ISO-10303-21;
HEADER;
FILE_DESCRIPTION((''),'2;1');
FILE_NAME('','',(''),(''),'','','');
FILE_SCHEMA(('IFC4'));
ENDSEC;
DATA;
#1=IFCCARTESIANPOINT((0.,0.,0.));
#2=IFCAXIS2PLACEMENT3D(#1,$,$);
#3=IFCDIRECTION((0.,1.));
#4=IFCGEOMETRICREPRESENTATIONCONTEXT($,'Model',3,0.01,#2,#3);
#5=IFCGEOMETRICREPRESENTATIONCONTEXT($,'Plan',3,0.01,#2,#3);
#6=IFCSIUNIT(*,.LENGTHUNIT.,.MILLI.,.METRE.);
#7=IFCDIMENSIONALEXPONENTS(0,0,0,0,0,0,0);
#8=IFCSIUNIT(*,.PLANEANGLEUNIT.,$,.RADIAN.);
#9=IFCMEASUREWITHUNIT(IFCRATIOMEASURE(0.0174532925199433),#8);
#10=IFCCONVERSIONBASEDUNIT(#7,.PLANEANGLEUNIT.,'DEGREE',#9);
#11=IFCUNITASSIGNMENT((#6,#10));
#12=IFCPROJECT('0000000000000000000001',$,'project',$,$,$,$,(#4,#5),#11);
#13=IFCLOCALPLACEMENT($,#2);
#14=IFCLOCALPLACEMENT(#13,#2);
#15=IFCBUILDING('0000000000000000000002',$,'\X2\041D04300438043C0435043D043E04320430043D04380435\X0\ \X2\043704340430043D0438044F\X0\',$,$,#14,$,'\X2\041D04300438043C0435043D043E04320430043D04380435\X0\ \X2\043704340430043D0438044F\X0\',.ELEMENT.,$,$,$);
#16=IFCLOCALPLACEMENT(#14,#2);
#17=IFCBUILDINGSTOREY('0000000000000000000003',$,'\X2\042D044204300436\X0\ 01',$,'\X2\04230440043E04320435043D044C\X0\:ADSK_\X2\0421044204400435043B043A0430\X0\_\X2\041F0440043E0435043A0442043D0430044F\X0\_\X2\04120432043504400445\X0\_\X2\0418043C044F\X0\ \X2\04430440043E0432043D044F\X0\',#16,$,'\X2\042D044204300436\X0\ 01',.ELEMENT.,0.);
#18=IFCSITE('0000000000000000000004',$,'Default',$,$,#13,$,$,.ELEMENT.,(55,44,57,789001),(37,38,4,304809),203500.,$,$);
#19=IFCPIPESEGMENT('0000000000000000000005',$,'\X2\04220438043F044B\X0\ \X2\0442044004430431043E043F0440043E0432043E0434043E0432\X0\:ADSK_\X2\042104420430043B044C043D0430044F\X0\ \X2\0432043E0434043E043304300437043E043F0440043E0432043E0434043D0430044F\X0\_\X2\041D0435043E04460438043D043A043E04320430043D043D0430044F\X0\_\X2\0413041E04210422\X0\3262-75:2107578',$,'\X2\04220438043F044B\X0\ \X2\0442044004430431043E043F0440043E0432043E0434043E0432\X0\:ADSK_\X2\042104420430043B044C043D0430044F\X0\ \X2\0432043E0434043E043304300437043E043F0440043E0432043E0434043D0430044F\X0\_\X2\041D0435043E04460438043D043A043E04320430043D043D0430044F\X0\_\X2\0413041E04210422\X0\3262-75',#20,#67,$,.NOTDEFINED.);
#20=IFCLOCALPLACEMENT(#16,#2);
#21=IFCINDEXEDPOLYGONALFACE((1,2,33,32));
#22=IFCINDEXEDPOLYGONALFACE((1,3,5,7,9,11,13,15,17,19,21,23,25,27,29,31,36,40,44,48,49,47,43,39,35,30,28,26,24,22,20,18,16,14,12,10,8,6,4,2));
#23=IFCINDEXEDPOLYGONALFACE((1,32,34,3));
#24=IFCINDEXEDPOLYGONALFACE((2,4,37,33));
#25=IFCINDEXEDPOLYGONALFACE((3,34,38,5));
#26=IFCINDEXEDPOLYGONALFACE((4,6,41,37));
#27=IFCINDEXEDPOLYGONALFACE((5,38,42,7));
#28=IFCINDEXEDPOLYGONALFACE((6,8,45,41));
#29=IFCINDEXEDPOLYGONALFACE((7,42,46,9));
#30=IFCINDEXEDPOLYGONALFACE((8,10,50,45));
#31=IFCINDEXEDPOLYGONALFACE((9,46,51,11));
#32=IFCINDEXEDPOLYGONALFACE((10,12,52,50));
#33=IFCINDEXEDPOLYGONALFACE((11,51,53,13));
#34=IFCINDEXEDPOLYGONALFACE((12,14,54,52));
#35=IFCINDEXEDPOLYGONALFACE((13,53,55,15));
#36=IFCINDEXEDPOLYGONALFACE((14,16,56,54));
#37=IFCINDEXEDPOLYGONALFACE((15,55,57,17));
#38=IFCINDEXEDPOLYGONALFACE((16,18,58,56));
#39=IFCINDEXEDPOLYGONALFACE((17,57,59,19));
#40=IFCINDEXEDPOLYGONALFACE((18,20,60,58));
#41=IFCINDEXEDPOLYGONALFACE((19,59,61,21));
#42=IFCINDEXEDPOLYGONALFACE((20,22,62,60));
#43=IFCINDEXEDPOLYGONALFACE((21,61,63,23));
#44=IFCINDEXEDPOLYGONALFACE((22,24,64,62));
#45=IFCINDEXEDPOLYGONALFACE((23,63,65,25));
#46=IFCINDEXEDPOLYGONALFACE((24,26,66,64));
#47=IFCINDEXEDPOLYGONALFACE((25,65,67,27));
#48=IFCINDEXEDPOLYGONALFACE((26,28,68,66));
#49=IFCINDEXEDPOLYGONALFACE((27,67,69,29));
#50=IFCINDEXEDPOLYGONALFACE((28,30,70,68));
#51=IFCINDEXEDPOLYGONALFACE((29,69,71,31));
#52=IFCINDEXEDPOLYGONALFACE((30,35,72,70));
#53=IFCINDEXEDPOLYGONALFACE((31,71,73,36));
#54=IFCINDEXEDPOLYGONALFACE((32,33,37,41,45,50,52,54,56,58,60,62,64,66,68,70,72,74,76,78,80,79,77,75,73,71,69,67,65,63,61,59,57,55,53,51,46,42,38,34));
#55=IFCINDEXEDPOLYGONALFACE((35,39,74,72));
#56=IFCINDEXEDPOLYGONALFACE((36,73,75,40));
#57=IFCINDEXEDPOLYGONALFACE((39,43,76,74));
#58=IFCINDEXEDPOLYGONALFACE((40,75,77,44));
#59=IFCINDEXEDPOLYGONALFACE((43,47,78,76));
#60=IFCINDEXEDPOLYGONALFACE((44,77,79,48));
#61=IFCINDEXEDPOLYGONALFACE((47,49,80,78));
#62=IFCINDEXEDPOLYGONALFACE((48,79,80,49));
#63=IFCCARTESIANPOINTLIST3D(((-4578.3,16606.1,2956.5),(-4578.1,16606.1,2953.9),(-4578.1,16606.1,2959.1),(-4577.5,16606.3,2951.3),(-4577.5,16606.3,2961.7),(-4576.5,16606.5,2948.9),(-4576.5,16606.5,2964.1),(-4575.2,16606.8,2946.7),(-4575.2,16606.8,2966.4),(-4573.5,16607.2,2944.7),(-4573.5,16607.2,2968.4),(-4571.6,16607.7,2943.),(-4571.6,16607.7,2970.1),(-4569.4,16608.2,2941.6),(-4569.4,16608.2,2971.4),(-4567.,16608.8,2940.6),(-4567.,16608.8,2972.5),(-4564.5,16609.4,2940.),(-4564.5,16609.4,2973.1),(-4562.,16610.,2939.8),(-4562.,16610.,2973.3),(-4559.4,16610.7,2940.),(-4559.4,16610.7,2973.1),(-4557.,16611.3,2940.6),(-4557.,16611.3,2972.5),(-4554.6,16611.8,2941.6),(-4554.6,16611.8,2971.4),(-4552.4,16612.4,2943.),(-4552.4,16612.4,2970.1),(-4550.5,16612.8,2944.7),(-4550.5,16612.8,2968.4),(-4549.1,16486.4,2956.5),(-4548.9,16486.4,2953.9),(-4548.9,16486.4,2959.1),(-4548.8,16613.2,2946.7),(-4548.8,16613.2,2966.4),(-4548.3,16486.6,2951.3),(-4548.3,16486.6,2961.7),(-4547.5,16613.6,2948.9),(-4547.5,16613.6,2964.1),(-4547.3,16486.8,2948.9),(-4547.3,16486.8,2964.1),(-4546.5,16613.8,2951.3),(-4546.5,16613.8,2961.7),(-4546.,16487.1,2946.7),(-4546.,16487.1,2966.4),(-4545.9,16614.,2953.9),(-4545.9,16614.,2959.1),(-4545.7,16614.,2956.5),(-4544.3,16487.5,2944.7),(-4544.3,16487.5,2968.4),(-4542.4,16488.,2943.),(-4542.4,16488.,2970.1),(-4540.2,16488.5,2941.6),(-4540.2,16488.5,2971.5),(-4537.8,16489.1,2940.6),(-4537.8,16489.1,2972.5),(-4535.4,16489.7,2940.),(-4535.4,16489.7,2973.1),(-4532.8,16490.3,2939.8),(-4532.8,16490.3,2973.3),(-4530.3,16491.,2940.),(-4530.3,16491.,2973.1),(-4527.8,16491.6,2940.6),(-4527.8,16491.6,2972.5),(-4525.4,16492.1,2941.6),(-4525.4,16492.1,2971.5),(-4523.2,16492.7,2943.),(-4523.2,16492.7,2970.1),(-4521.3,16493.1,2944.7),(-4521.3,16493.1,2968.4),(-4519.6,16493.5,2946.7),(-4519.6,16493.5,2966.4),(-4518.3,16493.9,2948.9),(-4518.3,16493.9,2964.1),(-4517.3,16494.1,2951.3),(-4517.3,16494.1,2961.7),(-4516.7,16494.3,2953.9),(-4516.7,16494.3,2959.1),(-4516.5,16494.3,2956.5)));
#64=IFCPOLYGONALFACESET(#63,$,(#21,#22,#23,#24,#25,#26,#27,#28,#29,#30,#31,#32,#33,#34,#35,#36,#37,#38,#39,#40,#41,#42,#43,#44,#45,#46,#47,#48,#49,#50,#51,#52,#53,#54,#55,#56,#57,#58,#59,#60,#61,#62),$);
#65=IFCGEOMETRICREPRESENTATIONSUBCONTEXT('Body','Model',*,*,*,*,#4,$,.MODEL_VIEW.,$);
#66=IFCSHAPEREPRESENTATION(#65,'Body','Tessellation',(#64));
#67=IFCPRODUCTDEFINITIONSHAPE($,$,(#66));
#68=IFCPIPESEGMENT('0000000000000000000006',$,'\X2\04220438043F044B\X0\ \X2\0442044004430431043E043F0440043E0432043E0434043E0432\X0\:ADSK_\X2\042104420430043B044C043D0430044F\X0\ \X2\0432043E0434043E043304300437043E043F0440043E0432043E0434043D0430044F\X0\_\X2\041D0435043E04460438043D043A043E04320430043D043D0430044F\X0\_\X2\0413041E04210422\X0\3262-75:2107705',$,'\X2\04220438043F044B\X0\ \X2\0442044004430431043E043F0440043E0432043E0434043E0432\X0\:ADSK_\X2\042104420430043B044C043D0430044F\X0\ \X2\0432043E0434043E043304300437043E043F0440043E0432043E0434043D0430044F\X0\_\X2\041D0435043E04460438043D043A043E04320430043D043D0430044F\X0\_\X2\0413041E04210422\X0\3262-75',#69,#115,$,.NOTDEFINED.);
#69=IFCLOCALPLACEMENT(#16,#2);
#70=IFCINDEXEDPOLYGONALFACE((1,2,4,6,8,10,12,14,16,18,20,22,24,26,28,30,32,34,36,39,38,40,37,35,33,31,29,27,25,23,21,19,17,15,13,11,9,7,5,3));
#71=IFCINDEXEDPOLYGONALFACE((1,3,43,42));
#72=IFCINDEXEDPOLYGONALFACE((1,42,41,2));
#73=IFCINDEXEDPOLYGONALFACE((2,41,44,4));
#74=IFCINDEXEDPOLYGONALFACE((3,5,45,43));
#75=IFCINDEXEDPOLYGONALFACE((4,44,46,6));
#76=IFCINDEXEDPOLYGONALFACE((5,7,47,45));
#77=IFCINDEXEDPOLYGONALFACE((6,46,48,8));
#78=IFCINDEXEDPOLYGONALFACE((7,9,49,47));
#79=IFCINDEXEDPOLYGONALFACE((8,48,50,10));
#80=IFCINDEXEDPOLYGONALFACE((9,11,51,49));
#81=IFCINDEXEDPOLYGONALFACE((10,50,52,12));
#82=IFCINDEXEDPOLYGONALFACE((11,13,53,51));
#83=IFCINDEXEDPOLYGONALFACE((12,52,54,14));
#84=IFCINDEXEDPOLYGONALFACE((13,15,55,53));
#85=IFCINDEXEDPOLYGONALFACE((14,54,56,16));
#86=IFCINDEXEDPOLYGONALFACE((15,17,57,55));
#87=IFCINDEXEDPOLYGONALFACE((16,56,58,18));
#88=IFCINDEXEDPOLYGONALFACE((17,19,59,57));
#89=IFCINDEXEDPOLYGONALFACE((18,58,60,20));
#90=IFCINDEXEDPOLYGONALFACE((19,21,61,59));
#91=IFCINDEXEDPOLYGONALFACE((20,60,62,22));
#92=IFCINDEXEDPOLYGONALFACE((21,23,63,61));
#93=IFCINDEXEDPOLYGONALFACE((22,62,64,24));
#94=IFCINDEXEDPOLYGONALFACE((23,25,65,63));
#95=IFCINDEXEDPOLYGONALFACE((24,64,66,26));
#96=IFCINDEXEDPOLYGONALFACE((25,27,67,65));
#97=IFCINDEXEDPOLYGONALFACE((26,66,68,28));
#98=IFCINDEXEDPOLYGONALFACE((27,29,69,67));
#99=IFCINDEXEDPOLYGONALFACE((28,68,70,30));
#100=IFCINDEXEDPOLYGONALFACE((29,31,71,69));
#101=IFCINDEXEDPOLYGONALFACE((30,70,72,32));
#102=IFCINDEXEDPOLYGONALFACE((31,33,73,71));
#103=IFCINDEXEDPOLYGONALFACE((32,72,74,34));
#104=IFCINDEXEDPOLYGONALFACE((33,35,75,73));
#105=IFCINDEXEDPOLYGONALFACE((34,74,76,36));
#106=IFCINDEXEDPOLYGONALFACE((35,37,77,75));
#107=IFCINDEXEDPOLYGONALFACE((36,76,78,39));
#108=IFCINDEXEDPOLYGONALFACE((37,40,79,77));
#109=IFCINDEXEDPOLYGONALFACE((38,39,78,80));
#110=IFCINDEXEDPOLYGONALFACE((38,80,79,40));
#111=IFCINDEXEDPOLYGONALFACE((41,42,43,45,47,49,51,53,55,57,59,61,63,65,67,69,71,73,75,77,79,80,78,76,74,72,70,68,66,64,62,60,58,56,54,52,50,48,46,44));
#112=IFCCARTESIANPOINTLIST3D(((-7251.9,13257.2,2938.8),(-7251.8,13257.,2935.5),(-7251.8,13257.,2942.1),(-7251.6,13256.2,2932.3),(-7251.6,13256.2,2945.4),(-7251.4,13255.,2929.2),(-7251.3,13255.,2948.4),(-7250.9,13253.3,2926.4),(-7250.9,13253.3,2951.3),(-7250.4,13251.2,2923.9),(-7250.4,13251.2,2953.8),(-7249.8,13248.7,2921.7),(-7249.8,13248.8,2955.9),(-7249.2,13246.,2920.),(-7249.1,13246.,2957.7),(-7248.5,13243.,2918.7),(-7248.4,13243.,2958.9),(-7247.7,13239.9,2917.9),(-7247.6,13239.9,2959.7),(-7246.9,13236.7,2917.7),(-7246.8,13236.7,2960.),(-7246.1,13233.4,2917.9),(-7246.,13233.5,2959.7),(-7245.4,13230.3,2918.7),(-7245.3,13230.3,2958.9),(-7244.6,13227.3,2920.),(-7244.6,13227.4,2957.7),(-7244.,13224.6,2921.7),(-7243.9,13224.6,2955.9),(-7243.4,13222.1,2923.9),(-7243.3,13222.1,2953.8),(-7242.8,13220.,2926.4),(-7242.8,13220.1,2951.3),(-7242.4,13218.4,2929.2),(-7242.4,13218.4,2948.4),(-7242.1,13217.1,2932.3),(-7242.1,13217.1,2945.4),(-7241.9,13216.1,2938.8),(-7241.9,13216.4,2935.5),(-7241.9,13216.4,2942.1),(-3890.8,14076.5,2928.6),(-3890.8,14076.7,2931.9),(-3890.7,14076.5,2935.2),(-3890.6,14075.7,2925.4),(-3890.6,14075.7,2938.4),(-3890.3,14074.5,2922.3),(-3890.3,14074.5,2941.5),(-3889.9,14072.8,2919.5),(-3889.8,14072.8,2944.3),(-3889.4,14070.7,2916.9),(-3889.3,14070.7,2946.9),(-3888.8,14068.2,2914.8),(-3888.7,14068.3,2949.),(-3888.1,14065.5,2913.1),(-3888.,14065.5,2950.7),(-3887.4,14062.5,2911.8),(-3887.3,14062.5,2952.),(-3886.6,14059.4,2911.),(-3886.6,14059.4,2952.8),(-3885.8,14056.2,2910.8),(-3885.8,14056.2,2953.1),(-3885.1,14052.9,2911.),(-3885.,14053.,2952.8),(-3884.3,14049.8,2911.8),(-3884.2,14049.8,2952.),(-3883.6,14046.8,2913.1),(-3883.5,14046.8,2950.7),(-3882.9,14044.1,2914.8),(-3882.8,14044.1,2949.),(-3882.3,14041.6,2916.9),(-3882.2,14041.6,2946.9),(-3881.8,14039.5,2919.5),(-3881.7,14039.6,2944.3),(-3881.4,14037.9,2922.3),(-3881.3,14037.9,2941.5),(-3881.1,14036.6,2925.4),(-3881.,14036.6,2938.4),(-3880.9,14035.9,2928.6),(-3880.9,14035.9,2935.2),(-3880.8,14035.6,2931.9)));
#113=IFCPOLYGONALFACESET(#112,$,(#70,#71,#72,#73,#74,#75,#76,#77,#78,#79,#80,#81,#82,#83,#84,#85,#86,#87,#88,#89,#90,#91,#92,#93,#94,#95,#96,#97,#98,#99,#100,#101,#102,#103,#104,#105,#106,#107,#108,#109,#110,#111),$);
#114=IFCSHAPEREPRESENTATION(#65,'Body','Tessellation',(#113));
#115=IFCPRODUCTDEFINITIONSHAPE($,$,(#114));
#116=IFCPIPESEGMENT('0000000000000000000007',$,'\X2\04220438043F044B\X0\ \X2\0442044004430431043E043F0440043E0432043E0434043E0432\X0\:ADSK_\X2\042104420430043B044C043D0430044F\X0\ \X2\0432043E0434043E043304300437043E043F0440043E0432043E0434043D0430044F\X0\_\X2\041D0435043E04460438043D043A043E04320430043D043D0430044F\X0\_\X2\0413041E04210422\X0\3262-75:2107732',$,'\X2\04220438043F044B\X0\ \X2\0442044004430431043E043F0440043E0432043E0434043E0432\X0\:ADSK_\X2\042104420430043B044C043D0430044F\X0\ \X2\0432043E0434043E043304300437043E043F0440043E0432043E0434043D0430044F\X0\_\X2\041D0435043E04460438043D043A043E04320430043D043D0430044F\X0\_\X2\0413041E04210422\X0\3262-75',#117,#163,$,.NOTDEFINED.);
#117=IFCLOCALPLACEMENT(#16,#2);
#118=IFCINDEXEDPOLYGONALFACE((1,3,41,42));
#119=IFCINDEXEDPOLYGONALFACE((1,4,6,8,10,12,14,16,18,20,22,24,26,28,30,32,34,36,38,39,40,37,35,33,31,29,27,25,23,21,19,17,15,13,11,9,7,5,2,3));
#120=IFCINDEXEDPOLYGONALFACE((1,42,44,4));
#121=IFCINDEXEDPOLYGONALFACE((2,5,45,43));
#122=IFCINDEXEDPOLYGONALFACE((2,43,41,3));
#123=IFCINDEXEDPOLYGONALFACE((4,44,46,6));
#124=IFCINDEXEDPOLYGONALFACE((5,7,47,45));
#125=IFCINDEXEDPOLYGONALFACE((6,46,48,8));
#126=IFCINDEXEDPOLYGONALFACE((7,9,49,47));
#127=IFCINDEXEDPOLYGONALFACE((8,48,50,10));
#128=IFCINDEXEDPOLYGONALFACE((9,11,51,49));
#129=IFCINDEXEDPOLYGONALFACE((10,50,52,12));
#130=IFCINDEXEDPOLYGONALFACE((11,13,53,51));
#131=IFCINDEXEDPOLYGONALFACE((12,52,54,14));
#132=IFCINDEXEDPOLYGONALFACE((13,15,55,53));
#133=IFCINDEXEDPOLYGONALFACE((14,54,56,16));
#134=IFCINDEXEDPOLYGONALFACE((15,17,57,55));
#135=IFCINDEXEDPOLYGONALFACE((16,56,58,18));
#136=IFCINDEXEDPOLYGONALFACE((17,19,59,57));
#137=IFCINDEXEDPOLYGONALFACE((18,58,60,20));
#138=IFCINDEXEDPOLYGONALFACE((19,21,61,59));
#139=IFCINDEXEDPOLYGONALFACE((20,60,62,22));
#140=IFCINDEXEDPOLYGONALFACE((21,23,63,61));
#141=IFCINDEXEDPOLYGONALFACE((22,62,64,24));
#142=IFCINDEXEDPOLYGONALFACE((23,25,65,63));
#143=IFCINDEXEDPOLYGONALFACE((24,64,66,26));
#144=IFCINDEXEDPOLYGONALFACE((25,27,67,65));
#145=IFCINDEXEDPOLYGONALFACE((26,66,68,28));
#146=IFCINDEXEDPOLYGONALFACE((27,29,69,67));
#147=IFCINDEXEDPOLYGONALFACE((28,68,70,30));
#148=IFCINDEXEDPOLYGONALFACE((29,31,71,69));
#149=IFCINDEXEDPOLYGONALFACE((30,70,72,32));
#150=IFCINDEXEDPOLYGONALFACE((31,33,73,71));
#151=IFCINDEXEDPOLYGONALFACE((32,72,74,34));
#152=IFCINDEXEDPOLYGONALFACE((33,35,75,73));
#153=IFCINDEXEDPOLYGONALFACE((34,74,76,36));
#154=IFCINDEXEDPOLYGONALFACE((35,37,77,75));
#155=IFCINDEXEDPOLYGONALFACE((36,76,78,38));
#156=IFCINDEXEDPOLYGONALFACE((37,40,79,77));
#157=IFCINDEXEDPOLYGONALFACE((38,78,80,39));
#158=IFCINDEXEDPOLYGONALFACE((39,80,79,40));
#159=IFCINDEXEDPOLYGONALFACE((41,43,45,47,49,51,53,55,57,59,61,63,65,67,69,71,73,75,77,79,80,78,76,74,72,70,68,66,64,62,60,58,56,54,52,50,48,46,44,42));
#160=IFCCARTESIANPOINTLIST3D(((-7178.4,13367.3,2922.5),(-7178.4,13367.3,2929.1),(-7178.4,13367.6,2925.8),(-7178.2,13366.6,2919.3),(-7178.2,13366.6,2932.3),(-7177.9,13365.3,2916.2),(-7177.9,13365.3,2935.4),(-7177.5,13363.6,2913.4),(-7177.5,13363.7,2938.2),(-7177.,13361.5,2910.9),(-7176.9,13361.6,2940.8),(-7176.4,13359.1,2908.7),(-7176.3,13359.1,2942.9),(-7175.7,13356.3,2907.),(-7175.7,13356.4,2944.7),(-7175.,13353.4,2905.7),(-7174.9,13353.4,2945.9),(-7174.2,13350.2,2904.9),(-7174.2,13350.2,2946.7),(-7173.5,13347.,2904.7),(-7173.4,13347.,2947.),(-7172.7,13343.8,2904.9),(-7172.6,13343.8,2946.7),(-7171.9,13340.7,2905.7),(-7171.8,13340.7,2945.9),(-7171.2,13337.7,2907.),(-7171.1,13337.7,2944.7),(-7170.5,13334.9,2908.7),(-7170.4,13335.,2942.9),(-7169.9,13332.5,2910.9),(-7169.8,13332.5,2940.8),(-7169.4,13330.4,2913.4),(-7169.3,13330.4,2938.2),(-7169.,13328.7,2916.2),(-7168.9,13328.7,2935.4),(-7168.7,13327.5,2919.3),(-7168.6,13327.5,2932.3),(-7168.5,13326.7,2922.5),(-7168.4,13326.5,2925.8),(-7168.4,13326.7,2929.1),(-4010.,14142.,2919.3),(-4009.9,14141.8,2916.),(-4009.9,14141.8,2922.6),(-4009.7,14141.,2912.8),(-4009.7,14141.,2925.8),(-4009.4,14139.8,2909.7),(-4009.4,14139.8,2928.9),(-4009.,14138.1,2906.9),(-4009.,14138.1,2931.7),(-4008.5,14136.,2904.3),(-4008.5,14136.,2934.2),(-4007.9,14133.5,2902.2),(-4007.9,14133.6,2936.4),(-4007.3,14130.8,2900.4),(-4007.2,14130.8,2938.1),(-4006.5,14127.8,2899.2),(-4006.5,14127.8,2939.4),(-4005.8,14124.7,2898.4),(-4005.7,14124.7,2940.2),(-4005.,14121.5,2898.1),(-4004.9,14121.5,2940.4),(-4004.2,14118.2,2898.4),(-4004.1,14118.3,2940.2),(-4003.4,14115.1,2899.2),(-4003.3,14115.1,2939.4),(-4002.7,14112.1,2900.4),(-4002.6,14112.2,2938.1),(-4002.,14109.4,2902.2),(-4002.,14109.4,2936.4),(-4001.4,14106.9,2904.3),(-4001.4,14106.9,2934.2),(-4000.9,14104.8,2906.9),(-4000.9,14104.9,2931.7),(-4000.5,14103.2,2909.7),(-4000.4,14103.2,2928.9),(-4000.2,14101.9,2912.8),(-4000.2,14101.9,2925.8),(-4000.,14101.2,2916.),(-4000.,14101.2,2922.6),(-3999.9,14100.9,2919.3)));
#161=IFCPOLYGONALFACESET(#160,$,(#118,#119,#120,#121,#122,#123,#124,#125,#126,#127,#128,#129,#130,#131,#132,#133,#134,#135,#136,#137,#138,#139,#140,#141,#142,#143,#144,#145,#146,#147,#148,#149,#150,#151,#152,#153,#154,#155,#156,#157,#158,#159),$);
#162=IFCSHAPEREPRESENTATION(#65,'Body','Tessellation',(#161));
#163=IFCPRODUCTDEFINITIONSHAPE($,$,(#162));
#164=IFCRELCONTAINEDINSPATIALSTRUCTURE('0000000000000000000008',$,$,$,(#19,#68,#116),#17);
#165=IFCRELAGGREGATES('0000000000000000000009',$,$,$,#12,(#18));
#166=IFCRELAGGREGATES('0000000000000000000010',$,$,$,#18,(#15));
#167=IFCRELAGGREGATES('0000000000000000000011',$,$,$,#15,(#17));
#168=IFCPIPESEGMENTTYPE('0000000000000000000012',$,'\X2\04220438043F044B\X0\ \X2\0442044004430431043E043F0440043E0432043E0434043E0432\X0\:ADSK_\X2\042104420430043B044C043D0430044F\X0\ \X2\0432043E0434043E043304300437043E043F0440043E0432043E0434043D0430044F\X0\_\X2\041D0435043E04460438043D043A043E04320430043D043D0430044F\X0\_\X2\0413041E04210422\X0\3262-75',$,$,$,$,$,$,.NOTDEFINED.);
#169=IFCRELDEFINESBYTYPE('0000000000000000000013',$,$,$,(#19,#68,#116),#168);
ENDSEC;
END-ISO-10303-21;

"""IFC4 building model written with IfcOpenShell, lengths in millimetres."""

from ifc_helpers import new_model, entity, si_unit, converted_unit, direction, frame, origin, place, context, subcontext, project, spatial, indexed_curve, outline, extrude, type_object, element, save


model = new_model("IFC4")

# Units and contexts
model_context = context("Model", 3, precision=0.01, world=origin(), true_north=direction((0.0, 1.0)))
plan_context = context("Plan", 3, precision=0.01, world=origin(), true_north=direction((0.0, 1.0)))
body_context = subcontext(model_context, "Body", "Model", "MODEL_VIEW")
ifc_project = project(units=[si_unit("LENGTHUNIT", "METRE", prefix="MILLI"), converted_unit("PLANEANGLEUNIT", "DEGREE", entity("IfcRatioMeasure", 0.0174532925199433), si_unit("PLANEANGLEUNIT", "RADIAN"), dimensions=[0, 0, 0, 0, 0, 0, 0])], contexts=[model_context, plan_context])

# Site, building, storey
site_placement = place(None, origin())
site = spatial("IfcSite", under=ifc_project, at=site_placement, Name="Default", CompositionType="ELEMENT", RefLatitude=(55, 44, 57, 789001), RefLongitude=(37, 38, 4, 304809), RefElevation=203500.0)
building_placement = place(site_placement, origin())
building = spatial("IfcBuilding", under=site, at=building_placement, Name="Наименование здания", LongName="Наименование здания", CompositionType="ELEMENT")
storey_placement = place(building_placement, origin())
storey = spatial("IfcBuildingStorey", under=building, at=storey_placement, Name="Этаж 01", ObjectType="Уровень:ADSK_Стрелка_Проектная_Вверх_Имя уровня", LongName="Этаж 01", CompositionType="ELEMENT", Elevation=0.0)

# Pipe segments
pipe_segment_type = type_object("IfcPipeSegmentType", Name="Типы трубопроводов:ADSK_Стальная водогазопроводная_Неоцинкованная_ГОСТ3262-75", PredefinedType="NOTDEFINED")
placement = place(storey_placement, origin())
element("IfcPipeSegment", 1, at=placement, inside=storey, type_object=pipe_segment_type, Name="Типы трубопроводов:ADSK_Стальная водогазопроводная_Неоцинкованная_ГОСТ3262-75:2107578", ObjectType="Типы трубопроводов:ADSK_Стальная водогазопроводная_Неоцинкованная_ГОСТ3262-75", PredefinedType="NOTDEFINED", context=body_context, shape_type="SweptSolid", body=[
    extrude(outline(indexed_curve([(16.8, 0.0), (16.5, 2.6), (15.9, 5.2), (14.9, 7.6), (13.6, 9.8), (11.8, 11.8), (9.8, 13.6), (7.6, 14.9), (5.2, 15.9), (2.6, 16.5), (0.0, 16.8), (-2.6, 16.5), (-5.2, 15.9), (-7.6, 14.9), (-9.8, 13.6), (-11.8, 11.8), (-13.6, 9.8), (-14.9, 7.6), (-15.9, 5.2), (-16.5, 2.6), (-16.7, 0.0), (-16.5, -2.6), (-15.9, -5.2), (-14.9, -7.6), (-13.6, -9.8), (-11.8, -11.8), (-9.8, -13.6), (-7.6, -14.9), (-5.2, -15.9), (-2.6, -16.5), (0.0, -16.8), (2.6, -16.5), (5.2, -15.9), (7.6, -14.9), (9.8, -13.6), (11.8, -11.8), (13.6, -9.8), (14.9, -7.6), (15.9, -5.2), (16.5, -2.6), (16.8, 0.0)], self_intersect=False)), frame((-4562.0, 16610.0, 2956.5), z_axis=(0.236826, -0.971552, 0.000046), x_axis=(0.971552, 0.236826, 0.0)), (0.0, 0.0, 1.0), 123.2),
])
element("IfcPipeSegment", 2, at=placement, inside=storey, type_object=pipe_segment_type, Name="Типы трубопроводов:ADSK_Стальная водогазопроводная_Неоцинкованная_ГОСТ3262-75:2107705", ObjectType="Типы трубопроводов:ADSK_Стальная водогазопроводная_Неоцинкованная_ГОСТ3262-75", PredefinedType="NOTDEFINED", context=body_context, shape_type="SweptSolid", body=[
    extrude(outline(indexed_curve([(21.1, 0.0), (20.9, 3.3), (20.1, 6.5), (18.8, 9.6), (17.1, 12.4), (15.0, 15.0), (12.4, 17.1), (9.6, 18.8), (6.5, 20.1), (3.3, 20.9), (0.0, 21.2), (-3.3, 20.9), (-6.5, 20.1), (-9.6, 18.8), (-12.4, 17.1), (-15.0, 15.0), (-17.1, 12.4), (-18.8, 9.6), (-20.1, 6.5), (-20.9, 3.3), (-21.1, 0.0), (-20.9, -3.3), (-20.1, -6.5), (-18.8, -9.6), (-17.1, -12.4), (-15.0, -15.0), (-12.4, -17.1), (-9.6, -18.8), (-6.5, -20.1), (-3.3, -20.9), (0.0, -21.2), (3.3, -20.9), (6.5, -20.1), (9.6, -18.8), (12.4, -17.1), (15.0, -15.0), (17.1, -12.4), (18.8, -9.6), (20.1, -6.5), (20.9, -3.3), (21.1, 0.0)], self_intersect=False)), frame((-7246.9, 13236.7, 2938.8), z_axis=(0.971536, 0.236882, -0.002), x_axis=(-0.236882, 0.971538, 0.0)), (0.0, 0.0, 1.0), 3459.5),
])
element("IfcPipeSegment", 3, at=placement, inside=storey, type_object=pipe_segment_type, Name="Типы трубопроводов:ADSK_Стальная водогазопроводная_Неоцинкованная_ГОСТ3262-75:2107732", ObjectType="Типы трубопроводов:ADSK_Стальная водогазопроводная_Неоцинкованная_ГОСТ3262-75", PredefinedType="NOTDEFINED", context=body_context, shape_type="SweptSolid", body=[
    extrude(outline(indexed_curve([(21.1, 0.0), (20.9, 3.3), (20.1, 6.5), (18.8, 9.6), (17.1, 12.4), (15.0, 15.0), (12.4, 17.1), (9.6, 18.8), (6.5, 20.1), (3.3, 20.9), (0.0, 21.2), (-3.3, 20.9), (-6.5, 20.1), (-9.6, 18.8), (-12.4, 17.1), (-15.0, 15.0), (-17.1, 12.4), (-18.8, 9.6), (-20.1, 6.5), (-20.9, 3.3), (-21.1, 0.0), (-20.9, -3.3), (-20.1, -6.5), (-18.8, -9.6), (-17.1, -12.4), (-15.0, -15.0), (-12.4, -17.1), (-9.6, -18.8), (-6.5, -20.1), (-3.3, -20.9), (0.0, -21.1), (3.3, -20.9), (6.5, -20.1), (9.6, -18.8), (12.4, -17.1), (15.0, -15.0), (17.1, -12.4), (18.8, -9.6), (20.1, -6.5), (20.9, -3.3), (21.1, 0.0)], self_intersect=False)), frame((-4004.9, 14121.5, 2919.3), z_axis=(-0.971402, -0.237432, 0.002), x_axis=(0.237432, -0.971404, 0.0)), (0.0, 0.0, 1.0), 3261.8),
])

save(model, "model.ifc")
